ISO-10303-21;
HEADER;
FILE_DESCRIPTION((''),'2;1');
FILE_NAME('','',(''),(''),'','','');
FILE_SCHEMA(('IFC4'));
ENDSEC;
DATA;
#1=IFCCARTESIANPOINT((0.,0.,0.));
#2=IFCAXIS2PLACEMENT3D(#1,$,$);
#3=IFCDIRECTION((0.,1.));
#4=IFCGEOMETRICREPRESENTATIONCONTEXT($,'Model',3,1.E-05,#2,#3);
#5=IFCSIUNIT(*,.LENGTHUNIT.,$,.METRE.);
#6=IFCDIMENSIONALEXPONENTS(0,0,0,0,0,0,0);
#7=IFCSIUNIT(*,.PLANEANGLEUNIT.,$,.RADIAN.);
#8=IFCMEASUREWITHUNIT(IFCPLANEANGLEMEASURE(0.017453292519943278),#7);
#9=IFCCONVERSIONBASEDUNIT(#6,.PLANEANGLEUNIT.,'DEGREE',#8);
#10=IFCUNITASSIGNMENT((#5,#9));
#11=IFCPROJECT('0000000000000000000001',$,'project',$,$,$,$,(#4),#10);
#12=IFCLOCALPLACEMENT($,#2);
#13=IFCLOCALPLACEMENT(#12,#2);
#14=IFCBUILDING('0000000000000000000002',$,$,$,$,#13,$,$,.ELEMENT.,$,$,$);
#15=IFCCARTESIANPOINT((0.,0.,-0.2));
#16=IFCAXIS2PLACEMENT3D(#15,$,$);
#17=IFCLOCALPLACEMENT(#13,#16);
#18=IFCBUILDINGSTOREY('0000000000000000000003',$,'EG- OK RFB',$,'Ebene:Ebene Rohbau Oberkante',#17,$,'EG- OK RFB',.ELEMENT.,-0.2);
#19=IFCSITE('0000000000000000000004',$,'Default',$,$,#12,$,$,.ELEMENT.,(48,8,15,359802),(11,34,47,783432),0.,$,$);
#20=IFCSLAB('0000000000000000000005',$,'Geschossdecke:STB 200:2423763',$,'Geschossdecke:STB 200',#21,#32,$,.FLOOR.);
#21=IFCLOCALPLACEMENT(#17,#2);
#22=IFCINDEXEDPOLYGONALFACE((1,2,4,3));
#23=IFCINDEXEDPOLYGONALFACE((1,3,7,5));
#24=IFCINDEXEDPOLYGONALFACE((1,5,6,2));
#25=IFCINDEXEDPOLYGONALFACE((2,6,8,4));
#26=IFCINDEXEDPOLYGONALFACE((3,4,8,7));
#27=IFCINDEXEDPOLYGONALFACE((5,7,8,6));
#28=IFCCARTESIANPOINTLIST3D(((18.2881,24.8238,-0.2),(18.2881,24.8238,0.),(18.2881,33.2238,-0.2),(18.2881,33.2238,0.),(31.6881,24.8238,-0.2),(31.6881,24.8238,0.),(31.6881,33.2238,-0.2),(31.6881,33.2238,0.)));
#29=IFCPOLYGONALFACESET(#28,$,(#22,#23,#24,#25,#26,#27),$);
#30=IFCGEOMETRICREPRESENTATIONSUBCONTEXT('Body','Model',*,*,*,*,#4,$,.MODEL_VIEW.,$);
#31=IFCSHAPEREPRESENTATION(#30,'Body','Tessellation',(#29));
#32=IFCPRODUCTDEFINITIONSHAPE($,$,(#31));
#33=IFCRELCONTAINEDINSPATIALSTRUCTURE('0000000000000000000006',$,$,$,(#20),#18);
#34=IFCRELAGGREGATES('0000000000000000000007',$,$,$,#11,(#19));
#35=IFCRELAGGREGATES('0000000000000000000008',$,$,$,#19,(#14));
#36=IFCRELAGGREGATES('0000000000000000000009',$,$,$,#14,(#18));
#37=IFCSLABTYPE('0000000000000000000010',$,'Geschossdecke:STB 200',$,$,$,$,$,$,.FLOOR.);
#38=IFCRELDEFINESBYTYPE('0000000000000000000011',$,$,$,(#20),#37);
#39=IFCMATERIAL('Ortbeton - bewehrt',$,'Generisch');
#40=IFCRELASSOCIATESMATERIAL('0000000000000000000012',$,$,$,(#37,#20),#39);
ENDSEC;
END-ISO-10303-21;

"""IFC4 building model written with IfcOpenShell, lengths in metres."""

from ifc_helpers import new_model, entity, si_unit, converted_unit, direction, frame, origin, place, context, subcontext, project, spatial, indexed_curve, outline, extrude, material, type_object, element, save


model = new_model("IFC4")

# Units and contexts
model_context = context("Model", 3, precision=1e-05, world=origin(), true_north=direction((0.0, 1.0)))
body_context = subcontext(model_context, "Body", "Model", "MODEL_VIEW")
ifc_project = project(units=[si_unit("LENGTHUNIT", "METRE"), converted_unit("PLANEANGLEUNIT", "DEGREE", entity("IfcPlaneAngleMeasure", 0.017453292519943278), si_unit("PLANEANGLEUNIT", "RADIAN"), dimensions=[0, 0, 0, 0, 0, 0, 0])], contexts=[model_context])

# Site, building, storey
site_placement = place(None, origin())
site = spatial("IfcSite", under=ifc_project, at=site_placement, Name="Default", CompositionType="ELEMENT", RefLatitude=(48, 8, 15, 359802), RefLongitude=(11, 34, 47, 783432), RefElevation=0.0)
building_placement = place(site_placement, origin())
building = spatial("IfcBuilding", under=site, at=building_placement, CompositionType="ELEMENT")
storey_placement = place(building_placement, frame((0.0, 0.0, -0.2)))
storey = spatial("IfcBuildingStorey", under=building, at=storey_placement, Name="EG- OK RFB", ObjectType="Ebene:Ebene Rohbau Oberkante", LongName="EG- OK RFB", CompositionType="ELEMENT", Elevation=-0.2)

# Slab
ifc_material = material(Name="Ortbeton - bewehrt", Category="Generisch")
slab_type = type_object("IfcSlabType", Name="Geschossdecke:STB 200", PredefinedType="FLOOR", material=ifc_material)
slab_placement = place(storey_placement, origin())
element("IfcSlab", 1, at=slab_placement, inside=storey, type_object=slab_type, material=ifc_material, Name="Geschossdecke:STB 200:2423763", ObjectType="Geschossdecke:STB 200", PredefinedType="FLOOR", context=body_context, shape_type="SweptSolid", body=[
    extrude(outline(indexed_curve([(-4.2, -6.7), (4.2, -6.7), (4.2, 6.7), (-4.2, 6.7), (-4.2, -6.7)], self_intersect=False)), frame((24.9881, 29.0238, 0.0), z_axis=(0.0, 0.0, -1.0), x_axis=(0.0, 1.0, 0.0)), (0.0, 0.0, 1.0), 0.2),
])

save(model, "model.ifc")
